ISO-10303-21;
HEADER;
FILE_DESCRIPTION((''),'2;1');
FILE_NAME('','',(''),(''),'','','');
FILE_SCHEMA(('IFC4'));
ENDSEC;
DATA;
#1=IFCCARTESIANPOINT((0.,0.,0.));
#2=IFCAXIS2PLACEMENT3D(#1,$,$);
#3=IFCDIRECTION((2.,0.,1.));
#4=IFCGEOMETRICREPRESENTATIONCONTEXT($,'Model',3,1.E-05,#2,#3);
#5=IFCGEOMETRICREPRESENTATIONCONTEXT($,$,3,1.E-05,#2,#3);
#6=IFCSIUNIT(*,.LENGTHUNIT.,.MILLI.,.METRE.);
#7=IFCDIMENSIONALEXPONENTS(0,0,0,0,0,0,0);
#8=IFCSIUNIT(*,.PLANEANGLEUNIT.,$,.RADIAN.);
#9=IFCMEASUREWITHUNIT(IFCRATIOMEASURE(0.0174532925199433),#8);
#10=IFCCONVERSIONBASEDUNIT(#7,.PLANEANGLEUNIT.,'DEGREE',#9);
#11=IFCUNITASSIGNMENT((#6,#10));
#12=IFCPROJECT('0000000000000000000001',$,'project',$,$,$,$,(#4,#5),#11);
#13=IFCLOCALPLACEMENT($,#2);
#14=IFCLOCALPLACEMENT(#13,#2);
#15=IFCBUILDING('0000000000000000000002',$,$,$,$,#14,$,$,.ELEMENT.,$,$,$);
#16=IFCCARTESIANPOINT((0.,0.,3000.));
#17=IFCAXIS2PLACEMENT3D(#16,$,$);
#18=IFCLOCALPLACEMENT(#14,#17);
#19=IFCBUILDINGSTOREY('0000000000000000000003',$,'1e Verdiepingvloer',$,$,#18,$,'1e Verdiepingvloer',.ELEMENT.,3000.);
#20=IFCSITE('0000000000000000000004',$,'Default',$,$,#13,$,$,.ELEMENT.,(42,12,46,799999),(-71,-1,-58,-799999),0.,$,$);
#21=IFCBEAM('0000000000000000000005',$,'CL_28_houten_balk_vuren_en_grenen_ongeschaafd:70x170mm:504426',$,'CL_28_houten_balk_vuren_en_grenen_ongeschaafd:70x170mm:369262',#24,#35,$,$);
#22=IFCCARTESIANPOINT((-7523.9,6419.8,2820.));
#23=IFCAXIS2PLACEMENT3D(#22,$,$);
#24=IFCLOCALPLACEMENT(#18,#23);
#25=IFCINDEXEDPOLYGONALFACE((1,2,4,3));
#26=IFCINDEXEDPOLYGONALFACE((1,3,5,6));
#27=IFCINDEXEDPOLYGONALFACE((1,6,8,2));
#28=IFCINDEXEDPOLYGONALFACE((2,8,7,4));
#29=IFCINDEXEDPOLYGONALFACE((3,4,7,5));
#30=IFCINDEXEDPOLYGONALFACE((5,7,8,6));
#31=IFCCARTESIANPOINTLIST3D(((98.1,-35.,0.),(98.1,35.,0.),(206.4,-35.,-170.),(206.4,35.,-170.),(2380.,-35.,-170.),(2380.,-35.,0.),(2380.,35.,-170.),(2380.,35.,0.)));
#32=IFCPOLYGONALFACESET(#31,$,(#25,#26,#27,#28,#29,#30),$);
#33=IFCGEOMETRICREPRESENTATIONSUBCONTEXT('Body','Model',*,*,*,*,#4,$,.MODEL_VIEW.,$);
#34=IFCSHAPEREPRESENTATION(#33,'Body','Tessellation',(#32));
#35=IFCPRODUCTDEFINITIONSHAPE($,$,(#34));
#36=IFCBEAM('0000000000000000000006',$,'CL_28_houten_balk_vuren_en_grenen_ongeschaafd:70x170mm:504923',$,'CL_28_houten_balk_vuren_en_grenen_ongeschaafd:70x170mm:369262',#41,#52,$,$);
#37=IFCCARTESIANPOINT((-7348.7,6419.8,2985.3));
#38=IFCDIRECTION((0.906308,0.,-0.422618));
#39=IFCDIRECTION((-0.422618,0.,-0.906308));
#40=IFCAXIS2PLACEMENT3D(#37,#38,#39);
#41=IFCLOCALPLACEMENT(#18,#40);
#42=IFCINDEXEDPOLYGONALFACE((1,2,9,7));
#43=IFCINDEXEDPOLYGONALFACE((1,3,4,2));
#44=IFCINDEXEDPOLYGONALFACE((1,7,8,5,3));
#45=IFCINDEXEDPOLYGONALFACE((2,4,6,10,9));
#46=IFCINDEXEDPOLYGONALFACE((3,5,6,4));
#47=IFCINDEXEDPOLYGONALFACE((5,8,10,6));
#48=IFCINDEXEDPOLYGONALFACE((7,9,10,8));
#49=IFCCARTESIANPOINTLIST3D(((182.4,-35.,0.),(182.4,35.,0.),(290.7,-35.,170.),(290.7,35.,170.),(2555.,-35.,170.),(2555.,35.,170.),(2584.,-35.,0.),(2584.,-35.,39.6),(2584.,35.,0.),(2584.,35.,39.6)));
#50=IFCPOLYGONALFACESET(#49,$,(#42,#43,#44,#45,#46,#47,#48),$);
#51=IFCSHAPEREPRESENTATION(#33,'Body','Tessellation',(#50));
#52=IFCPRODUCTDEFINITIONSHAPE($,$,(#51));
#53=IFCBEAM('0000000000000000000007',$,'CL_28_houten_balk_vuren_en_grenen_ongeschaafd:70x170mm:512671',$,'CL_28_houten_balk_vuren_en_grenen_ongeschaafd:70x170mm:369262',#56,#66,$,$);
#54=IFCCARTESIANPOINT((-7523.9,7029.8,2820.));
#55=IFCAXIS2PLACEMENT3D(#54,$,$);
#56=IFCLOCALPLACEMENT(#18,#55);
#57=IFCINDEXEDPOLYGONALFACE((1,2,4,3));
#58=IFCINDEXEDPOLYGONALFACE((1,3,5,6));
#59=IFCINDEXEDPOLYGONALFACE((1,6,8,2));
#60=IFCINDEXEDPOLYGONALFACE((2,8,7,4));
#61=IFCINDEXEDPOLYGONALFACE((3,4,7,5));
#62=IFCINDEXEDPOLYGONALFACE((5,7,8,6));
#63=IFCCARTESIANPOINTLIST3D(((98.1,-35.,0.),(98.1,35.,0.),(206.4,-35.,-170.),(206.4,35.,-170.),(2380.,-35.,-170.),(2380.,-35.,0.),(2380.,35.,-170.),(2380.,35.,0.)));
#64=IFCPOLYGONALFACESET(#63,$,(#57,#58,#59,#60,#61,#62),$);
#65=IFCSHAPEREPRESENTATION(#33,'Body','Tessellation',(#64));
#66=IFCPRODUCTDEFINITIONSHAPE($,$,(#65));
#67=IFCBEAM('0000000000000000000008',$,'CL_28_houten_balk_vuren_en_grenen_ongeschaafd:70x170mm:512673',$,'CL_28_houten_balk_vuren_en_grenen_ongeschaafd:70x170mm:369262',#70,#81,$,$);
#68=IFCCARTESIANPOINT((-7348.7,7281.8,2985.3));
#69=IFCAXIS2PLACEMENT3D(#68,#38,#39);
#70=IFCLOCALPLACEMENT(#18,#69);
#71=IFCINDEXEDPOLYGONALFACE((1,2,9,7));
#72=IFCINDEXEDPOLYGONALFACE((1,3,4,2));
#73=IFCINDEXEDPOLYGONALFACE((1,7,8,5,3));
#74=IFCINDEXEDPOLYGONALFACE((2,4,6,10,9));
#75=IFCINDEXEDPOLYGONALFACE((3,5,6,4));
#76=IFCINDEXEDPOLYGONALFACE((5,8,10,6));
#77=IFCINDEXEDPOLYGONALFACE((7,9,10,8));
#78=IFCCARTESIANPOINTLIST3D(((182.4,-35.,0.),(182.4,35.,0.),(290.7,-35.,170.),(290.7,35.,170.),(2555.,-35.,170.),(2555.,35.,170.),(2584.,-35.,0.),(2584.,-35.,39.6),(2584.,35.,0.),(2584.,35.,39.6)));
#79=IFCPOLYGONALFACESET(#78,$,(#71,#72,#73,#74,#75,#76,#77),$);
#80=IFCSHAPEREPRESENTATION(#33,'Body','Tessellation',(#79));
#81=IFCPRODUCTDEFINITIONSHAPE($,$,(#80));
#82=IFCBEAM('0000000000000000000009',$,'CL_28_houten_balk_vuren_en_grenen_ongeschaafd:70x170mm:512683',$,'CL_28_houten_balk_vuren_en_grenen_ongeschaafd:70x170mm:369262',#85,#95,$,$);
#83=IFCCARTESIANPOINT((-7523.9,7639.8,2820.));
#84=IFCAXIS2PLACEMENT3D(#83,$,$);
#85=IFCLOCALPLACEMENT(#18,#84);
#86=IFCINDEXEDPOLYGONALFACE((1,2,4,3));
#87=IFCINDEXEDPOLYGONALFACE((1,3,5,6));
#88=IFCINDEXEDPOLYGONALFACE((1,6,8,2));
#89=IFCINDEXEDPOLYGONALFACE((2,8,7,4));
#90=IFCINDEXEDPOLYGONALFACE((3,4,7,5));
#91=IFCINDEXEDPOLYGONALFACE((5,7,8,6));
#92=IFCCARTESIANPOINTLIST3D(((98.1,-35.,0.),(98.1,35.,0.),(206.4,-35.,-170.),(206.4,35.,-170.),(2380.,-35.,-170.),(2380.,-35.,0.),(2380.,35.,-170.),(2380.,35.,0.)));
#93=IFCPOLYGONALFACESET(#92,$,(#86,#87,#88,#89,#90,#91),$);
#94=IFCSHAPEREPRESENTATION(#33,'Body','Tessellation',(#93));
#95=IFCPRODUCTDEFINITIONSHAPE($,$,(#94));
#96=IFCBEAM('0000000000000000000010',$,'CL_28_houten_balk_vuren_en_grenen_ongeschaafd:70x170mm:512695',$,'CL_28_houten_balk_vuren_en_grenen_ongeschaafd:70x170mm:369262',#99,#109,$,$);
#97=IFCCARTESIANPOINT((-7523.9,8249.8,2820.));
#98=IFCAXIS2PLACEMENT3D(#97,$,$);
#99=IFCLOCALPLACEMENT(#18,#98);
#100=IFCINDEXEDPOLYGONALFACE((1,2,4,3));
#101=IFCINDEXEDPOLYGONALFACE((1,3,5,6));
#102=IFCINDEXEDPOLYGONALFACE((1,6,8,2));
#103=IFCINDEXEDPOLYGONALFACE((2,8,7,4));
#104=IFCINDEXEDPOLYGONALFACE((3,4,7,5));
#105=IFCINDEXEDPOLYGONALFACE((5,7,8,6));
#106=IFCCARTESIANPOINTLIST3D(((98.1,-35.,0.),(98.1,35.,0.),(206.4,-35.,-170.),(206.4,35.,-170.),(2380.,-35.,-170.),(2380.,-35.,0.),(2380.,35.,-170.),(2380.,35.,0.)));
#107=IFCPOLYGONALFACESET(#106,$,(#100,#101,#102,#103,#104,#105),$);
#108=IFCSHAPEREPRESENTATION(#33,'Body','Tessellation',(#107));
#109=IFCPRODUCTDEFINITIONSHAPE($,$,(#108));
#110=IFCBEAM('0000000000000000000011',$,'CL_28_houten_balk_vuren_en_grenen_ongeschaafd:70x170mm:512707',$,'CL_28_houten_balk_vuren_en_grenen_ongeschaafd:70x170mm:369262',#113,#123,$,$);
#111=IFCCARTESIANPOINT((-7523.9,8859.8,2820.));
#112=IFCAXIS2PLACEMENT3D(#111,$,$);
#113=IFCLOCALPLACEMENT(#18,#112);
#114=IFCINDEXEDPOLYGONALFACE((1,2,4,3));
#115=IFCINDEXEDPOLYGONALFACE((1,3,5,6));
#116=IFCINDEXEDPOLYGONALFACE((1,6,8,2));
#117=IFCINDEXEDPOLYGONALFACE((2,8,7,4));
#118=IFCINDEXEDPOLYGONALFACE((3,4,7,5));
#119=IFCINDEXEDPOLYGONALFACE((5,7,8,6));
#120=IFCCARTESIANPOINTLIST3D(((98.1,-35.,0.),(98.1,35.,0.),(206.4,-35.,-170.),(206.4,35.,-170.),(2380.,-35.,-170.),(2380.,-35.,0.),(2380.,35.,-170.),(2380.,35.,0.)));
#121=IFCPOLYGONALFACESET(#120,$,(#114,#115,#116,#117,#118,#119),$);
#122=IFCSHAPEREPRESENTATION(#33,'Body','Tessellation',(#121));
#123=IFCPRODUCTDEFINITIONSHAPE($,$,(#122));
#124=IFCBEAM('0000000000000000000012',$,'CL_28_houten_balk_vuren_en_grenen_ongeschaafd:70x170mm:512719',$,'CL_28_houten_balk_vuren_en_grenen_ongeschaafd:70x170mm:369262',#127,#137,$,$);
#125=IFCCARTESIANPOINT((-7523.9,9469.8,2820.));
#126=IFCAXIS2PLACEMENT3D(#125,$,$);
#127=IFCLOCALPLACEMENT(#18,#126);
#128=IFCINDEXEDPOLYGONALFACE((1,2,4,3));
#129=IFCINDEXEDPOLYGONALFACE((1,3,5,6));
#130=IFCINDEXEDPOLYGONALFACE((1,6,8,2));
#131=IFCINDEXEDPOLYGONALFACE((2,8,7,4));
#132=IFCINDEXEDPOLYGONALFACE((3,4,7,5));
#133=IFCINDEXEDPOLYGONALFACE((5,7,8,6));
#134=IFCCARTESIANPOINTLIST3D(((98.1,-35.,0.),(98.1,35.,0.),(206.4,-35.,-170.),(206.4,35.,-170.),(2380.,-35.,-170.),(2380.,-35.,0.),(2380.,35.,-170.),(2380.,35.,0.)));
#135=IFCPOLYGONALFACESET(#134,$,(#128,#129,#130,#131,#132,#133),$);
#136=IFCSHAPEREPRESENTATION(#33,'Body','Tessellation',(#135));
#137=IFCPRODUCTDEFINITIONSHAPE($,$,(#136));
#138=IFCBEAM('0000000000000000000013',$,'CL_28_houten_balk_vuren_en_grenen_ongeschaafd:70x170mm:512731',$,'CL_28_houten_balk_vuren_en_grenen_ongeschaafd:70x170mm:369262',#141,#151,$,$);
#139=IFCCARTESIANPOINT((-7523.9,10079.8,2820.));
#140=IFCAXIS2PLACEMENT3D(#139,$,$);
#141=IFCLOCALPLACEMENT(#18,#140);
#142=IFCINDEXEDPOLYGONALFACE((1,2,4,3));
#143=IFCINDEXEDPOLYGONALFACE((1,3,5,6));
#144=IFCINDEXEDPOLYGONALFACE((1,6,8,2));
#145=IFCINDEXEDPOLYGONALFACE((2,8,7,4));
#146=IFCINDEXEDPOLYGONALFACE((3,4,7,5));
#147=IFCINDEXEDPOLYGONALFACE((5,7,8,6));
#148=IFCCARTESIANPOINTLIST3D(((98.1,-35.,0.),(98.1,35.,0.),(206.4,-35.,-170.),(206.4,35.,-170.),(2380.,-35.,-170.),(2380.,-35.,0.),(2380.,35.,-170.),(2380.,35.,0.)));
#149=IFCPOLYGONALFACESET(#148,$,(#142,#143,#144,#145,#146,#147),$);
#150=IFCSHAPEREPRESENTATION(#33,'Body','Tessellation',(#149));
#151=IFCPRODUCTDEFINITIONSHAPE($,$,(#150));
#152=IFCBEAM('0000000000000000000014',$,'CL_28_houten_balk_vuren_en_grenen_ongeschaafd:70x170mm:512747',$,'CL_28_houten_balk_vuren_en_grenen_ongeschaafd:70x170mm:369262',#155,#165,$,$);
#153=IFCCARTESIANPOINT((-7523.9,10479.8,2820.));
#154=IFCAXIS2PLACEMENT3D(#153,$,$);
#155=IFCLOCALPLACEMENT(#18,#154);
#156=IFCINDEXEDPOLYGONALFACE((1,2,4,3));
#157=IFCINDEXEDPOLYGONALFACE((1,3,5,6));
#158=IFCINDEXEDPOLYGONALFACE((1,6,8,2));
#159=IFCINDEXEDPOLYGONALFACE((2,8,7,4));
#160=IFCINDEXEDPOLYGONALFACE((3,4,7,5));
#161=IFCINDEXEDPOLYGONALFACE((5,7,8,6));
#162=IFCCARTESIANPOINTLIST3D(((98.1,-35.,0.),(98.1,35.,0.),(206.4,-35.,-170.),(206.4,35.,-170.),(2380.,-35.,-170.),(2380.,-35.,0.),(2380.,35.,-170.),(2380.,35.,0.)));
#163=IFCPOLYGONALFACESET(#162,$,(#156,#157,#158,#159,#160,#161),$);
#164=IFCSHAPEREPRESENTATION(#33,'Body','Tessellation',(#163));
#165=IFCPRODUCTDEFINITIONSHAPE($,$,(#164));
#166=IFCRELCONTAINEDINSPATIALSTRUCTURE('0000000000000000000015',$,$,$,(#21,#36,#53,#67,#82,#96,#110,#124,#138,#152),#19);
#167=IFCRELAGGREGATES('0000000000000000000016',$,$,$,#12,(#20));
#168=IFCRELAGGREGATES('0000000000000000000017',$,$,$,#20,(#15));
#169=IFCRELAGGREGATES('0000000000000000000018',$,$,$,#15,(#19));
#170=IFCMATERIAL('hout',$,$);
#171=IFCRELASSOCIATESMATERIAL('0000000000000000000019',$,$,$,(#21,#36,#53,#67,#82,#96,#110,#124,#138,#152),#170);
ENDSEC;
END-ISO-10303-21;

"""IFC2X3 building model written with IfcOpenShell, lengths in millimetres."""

from ifc_helpers import new_model, entity, si_unit, converted_unit, direction, frame, frame_2d, origin, place, context, subcontext, project, spatial, rectangle, extrude, clip, halfspace, material, element, save


model = new_model("IFC2X3")

# Units and contexts
model_context = context("Model", 3, precision=1e-05, world=origin(), true_north=direction((2.0, 0.0, 1.0)))
context_of_model = context(None, 3, precision=1e-05, world=origin(), true_north=direction((2.0, 0.0, 1.0)))
body_context = subcontext(model_context, "Body", "Model", "MODEL_VIEW")
ifc_project = project(units=[si_unit("LENGTHUNIT", "METRE", prefix="MILLI"), converted_unit("PLANEANGLEUNIT", "DEGREE", entity("IfcRatioMeasure", 0.0174532925199433), si_unit("PLANEANGLEUNIT", "RADIAN"), dimensions=[0, 0, 0, 0, 0, 0, 0])], contexts=[model_context, context_of_model])

# Site, building, storey
site_placement = place(None, origin())
site = spatial("IfcSite", under=ifc_project, at=site_placement, Name="Default", CompositionType="ELEMENT", RefLatitude=(42, 12, 46, 799999), RefLongitude=(-71, -1, -58, -799999), RefElevation=0.0)
building_placement = place(site_placement, origin())
building = spatial("IfcBuilding", under=site, at=building_placement, CompositionType="ELEMENT")
storey_placement = place(building_placement, frame((0.0, 0.0, 3000.0)))
storey = spatial("IfcBuildingStorey", under=building, at=storey_placement, Name="1e Verdiepingvloer", LongName="1e Verdiepingvloer", CompositionType="ELEMENT", Elevation=3000.0)

# Beams
ifc_material_1 = material(Name="hout")
beam_1_placement = place(storey_placement, frame((-7523.9, 6419.8, 2820.0)))
element("IfcBeam", 1, at=beam_1_placement, inside=storey, material=ifc_material_1, Name="CL_28_houten_balk_vuren_en_grenen_ongeschaafd:70x170mm:504426", ObjectType="CL_28_houten_balk_vuren_en_grenen_ongeschaafd:70x170mm:369262", context=body_context, shape_type="Clipping", body=[
    clip(extrude(rectangle(XDim=170.0, YDim=70.0, at=frame_2d((0.0, 0.0), x_axis=(1.0, 0.0))), frame((98.1, 0.0, -85.0), z_axis=(1.0, 0.0, 0.0), x_axis=(0.0, 0.0, -1.0)), (0.0, 0.0, 1.0), 2281.9), halfspace(frame((206.4, -683.2, -170.0), z_axis=(-0.843391, 0.0, -0.5373), x_axis=(0.5373, 0.0, -0.843391)), False)),
])
beam_2_placement = place(storey_placement, frame((-7348.7, 6419.8, 2985.3), z_axis=(0.906308, 0.0, -0.422618), x_axis=(-0.422618, 0.0, -0.906308)))
element("IfcBeam", 2, at=beam_2_placement, inside=storey, material=ifc_material_1, Name="CL_28_houten_balk_vuren_en_grenen_ongeschaafd:70x170mm:504923", ObjectType="CL_28_houten_balk_vuren_en_grenen_ongeschaafd:70x170mm:369262", context=body_context, shape_type="Clipping", body=[
    clip(clip(extrude(rectangle(XDim=170.0, YDim=70.0, at=frame_2d((0.0, 0.0), x_axis=(0.0, 1.0))), frame((182.4, 0.0, 85.0), z_axis=(1.0, 0.0, 0.0), x_axis=(0.0, 1.0, 0.0)), (0.0, 0.0, 1.0), 2401.5), halfspace(frame((2590.9, -1982.2, 8.5), z_axis=(0.976296, 0.0, 0.21644), x_axis=(-0.21644, 0.0, 0.976296)), False)), halfspace(frame((290.7, -683.2, 170.0), z_axis=(-0.843391, 0.0, 0.5373), x_axis=(0.5373, 0.0, 0.843391)), False)),
])
beam_3_placement = place(storey_placement, frame((-7523.9, 7029.8, 2820.0)))
element("IfcBeam", 3, at=beam_3_placement, inside=storey, material=ifc_material_1, Name="CL_28_houten_balk_vuren_en_grenen_ongeschaafd:70x170mm:512671", ObjectType="CL_28_houten_balk_vuren_en_grenen_ongeschaafd:70x170mm:369262", context=body_context, shape_type="Clipping", body=[
    clip(extrude(rectangle(XDim=170.0, YDim=70.0, at=frame_2d((0.0, 0.0), x_axis=(1.0, 0.0))), frame((98.1, 0.0, -85.0), z_axis=(1.0, 0.0, 0.0), x_axis=(0.0, 0.0, -1.0)), (0.0, 0.0, 1.0), 2281.9), halfspace(frame((206.4, -1293.2, -170.0), z_axis=(-0.843391, 0.0, -0.5373), x_axis=(0.5373, 0.0, -0.843391)), False)),
])
beam_4_placement = place(storey_placement, frame((-7348.7, 7281.8, 2985.3), z_axis=(0.906308, 0.0, -0.422618), x_axis=(-0.422618, 0.0, -0.906308)))
element("IfcBeam", 4, at=beam_4_placement, inside=storey, material=ifc_material_1, Name="CL_28_houten_balk_vuren_en_grenen_ongeschaafd:70x170mm:512673", ObjectType="CL_28_houten_balk_vuren_en_grenen_ongeschaafd:70x170mm:369262", context=body_context, shape_type="Clipping", body=[
    clip(clip(extrude(rectangle(XDim=170.0, YDim=70.0, at=frame_2d((0.0, 0.0), x_axis=(0.0, 1.0))), frame((182.4, 0.0, 85.0), z_axis=(1.0, 0.0, 0.0), x_axis=(0.0, 1.0, 0.0)), (0.0, 0.0, 1.0), 2401.5), halfspace(frame((2590.9, -2844.2, 8.5), z_axis=(0.976296, 0.0, 0.21644), x_axis=(-0.21644, 0.0, 0.976296)), False)), halfspace(frame((290.7, -1545.2, 170.0), z_axis=(-0.843391, 0.0, 0.5373), x_axis=(0.5373, 0.0, 0.843391)), False)),
])
beam_5_placement = place(storey_placement, frame((-7523.9, 7639.8, 2820.0)))
element("IfcBeam", 5, at=beam_5_placement, inside=storey, material=ifc_material_1, Name="CL_28_houten_balk_vuren_en_grenen_ongeschaafd:70x170mm:512683", ObjectType="CL_28_houten_balk_vuren_en_grenen_ongeschaafd:70x170mm:369262", context=body_context, shape_type="Clipping", body=[
    clip(extrude(rectangle(XDim=170.0, YDim=70.0, at=frame_2d((0.0, 0.0), x_axis=(1.0, 0.0))), frame((98.1, 0.0, -85.0), z_axis=(1.0, 0.0, 0.0), x_axis=(0.0, 0.0, -1.0)), (0.0, 0.0, 1.0), 2281.9), halfspace(frame((206.4, -1903.2, -170.0), z_axis=(-0.843391, 0.0, -0.5373), x_axis=(0.5373, 0.0, -0.843391)), False)),
])
beam_6_placement = place(storey_placement, frame((-7523.9, 8249.8, 2820.0)))
element("IfcBeam", 6, at=beam_6_placement, inside=storey, material=ifc_material_1, Name="CL_28_houten_balk_vuren_en_grenen_ongeschaafd:70x170mm:512695", ObjectType="CL_28_houten_balk_vuren_en_grenen_ongeschaafd:70x170mm:369262", context=body_context, shape_type="Clipping", body=[
    clip(extrude(rectangle(XDim=170.0, YDim=70.0, at=frame_2d((0.0, 0.0), x_axis=(1.0, 0.0))), frame((98.1, 0.0, -85.0), z_axis=(1.0, 0.0, 0.0), x_axis=(0.0, 0.0, -1.0)), (0.0, 0.0, 1.0), 2281.9), halfspace(frame((206.4, -2513.2, -170.0), z_axis=(-0.843391, 0.0, -0.5373), x_axis=(0.5373, 0.0, -0.843391)), False)),
])
beam_7_placement = place(storey_placement, frame((-7523.9, 8859.8, 2820.0)))
element("IfcBeam", 7, at=beam_7_placement, inside=storey, material=ifc_material_1, Name="CL_28_houten_balk_vuren_en_grenen_ongeschaafd:70x170mm:512707", ObjectType="CL_28_houten_balk_vuren_en_grenen_ongeschaafd:70x170mm:369262", context=body_context, shape_type="Clipping", body=[
    clip(extrude(rectangle(XDim=170.0, YDim=70.0, at=frame_2d((0.0, 0.0), x_axis=(1.0, 0.0))), frame((98.1, 0.0, -85.0), z_axis=(1.0, 0.0, 0.0), x_axis=(0.0, 0.0, -1.0)), (0.0, 0.0, 1.0), 2281.9), halfspace(frame((206.4, -3123.2, -170.0), z_axis=(-0.843391, 0.0, -0.5373), x_axis=(0.5373, 0.0, -0.843391)), False)),
])
beam_8_placement = place(storey_placement, frame((-7523.9, 9469.8, 2820.0)))
element("IfcBeam", 8, at=beam_8_placement, inside=storey, material=ifc_material_1, Name="CL_28_houten_balk_vuren_en_grenen_ongeschaafd:70x170mm:512719", ObjectType="CL_28_houten_balk_vuren_en_grenen_ongeschaafd:70x170mm:369262", context=body_context, shape_type="Clipping", body=[
    clip(extrude(rectangle(XDim=170.0, YDim=70.0, at=frame_2d((0.0, 0.0), x_axis=(1.0, 0.0))), frame((98.1, 0.0, -85.0), z_axis=(1.0, 0.0, 0.0), x_axis=(0.0, 0.0, -1.0)), (0.0, 0.0, 1.0), 2281.9), halfspace(frame((206.4, -3733.2, -170.0), z_axis=(-0.843391, 0.0, -0.5373), x_axis=(0.5373, 0.0, -0.843391)), False)),
])
beam_9_placement = place(storey_placement, frame((-7523.9, 10079.8, 2820.0)))
element("IfcBeam", 9, at=beam_9_placement, inside=storey, material=ifc_material_1, Name="CL_28_houten_balk_vuren_en_grenen_ongeschaafd:70x170mm:512731", ObjectType="CL_28_houten_balk_vuren_en_grenen_ongeschaafd:70x170mm:369262", context=body_context, shape_type="Clipping", body=[
    clip(extrude(rectangle(XDim=170.0, YDim=70.0, at=frame_2d((0.0, 0.0), x_axis=(1.0, 0.0))), frame((98.1, 0.0, -85.0), z_axis=(1.0, 0.0, 0.0), x_axis=(0.0, 0.0, -1.0)), (0.0, 0.0, 1.0), 2281.9), halfspace(frame((206.4, -4343.2, -170.0), z_axis=(-0.843391, 0.0, -0.5373), x_axis=(0.5373, 0.0, -0.843391)), False)),
])
beam_10_placement = place(storey_placement, frame((-7523.9, 10479.8, 2820.0)))
element("IfcBeam", 10, at=beam_10_placement, inside=storey, material=ifc_material_1, Name="CL_28_houten_balk_vuren_en_grenen_ongeschaafd:70x170mm:512747", ObjectType="CL_28_houten_balk_vuren_en_grenen_ongeschaafd:70x170mm:369262", context=body_context, shape_type="Clipping", body=[
    clip(extrude(rectangle(XDim=170.0, YDim=70.0, at=frame_2d((0.0, 0.0), x_axis=(1.0, 0.0))), frame((98.1, 0.0, -85.0), z_axis=(1.0, 0.0, 0.0), x_axis=(0.0, 0.0, -1.0)), (0.0, 0.0, 1.0), 2281.9), halfspace(frame((206.4, -4743.2, -170.0), z_axis=(-0.843391, 0.0, -0.5373), x_axis=(0.5373, 0.0, -0.843391)), False)),
])

save(model, "model.ifc")
